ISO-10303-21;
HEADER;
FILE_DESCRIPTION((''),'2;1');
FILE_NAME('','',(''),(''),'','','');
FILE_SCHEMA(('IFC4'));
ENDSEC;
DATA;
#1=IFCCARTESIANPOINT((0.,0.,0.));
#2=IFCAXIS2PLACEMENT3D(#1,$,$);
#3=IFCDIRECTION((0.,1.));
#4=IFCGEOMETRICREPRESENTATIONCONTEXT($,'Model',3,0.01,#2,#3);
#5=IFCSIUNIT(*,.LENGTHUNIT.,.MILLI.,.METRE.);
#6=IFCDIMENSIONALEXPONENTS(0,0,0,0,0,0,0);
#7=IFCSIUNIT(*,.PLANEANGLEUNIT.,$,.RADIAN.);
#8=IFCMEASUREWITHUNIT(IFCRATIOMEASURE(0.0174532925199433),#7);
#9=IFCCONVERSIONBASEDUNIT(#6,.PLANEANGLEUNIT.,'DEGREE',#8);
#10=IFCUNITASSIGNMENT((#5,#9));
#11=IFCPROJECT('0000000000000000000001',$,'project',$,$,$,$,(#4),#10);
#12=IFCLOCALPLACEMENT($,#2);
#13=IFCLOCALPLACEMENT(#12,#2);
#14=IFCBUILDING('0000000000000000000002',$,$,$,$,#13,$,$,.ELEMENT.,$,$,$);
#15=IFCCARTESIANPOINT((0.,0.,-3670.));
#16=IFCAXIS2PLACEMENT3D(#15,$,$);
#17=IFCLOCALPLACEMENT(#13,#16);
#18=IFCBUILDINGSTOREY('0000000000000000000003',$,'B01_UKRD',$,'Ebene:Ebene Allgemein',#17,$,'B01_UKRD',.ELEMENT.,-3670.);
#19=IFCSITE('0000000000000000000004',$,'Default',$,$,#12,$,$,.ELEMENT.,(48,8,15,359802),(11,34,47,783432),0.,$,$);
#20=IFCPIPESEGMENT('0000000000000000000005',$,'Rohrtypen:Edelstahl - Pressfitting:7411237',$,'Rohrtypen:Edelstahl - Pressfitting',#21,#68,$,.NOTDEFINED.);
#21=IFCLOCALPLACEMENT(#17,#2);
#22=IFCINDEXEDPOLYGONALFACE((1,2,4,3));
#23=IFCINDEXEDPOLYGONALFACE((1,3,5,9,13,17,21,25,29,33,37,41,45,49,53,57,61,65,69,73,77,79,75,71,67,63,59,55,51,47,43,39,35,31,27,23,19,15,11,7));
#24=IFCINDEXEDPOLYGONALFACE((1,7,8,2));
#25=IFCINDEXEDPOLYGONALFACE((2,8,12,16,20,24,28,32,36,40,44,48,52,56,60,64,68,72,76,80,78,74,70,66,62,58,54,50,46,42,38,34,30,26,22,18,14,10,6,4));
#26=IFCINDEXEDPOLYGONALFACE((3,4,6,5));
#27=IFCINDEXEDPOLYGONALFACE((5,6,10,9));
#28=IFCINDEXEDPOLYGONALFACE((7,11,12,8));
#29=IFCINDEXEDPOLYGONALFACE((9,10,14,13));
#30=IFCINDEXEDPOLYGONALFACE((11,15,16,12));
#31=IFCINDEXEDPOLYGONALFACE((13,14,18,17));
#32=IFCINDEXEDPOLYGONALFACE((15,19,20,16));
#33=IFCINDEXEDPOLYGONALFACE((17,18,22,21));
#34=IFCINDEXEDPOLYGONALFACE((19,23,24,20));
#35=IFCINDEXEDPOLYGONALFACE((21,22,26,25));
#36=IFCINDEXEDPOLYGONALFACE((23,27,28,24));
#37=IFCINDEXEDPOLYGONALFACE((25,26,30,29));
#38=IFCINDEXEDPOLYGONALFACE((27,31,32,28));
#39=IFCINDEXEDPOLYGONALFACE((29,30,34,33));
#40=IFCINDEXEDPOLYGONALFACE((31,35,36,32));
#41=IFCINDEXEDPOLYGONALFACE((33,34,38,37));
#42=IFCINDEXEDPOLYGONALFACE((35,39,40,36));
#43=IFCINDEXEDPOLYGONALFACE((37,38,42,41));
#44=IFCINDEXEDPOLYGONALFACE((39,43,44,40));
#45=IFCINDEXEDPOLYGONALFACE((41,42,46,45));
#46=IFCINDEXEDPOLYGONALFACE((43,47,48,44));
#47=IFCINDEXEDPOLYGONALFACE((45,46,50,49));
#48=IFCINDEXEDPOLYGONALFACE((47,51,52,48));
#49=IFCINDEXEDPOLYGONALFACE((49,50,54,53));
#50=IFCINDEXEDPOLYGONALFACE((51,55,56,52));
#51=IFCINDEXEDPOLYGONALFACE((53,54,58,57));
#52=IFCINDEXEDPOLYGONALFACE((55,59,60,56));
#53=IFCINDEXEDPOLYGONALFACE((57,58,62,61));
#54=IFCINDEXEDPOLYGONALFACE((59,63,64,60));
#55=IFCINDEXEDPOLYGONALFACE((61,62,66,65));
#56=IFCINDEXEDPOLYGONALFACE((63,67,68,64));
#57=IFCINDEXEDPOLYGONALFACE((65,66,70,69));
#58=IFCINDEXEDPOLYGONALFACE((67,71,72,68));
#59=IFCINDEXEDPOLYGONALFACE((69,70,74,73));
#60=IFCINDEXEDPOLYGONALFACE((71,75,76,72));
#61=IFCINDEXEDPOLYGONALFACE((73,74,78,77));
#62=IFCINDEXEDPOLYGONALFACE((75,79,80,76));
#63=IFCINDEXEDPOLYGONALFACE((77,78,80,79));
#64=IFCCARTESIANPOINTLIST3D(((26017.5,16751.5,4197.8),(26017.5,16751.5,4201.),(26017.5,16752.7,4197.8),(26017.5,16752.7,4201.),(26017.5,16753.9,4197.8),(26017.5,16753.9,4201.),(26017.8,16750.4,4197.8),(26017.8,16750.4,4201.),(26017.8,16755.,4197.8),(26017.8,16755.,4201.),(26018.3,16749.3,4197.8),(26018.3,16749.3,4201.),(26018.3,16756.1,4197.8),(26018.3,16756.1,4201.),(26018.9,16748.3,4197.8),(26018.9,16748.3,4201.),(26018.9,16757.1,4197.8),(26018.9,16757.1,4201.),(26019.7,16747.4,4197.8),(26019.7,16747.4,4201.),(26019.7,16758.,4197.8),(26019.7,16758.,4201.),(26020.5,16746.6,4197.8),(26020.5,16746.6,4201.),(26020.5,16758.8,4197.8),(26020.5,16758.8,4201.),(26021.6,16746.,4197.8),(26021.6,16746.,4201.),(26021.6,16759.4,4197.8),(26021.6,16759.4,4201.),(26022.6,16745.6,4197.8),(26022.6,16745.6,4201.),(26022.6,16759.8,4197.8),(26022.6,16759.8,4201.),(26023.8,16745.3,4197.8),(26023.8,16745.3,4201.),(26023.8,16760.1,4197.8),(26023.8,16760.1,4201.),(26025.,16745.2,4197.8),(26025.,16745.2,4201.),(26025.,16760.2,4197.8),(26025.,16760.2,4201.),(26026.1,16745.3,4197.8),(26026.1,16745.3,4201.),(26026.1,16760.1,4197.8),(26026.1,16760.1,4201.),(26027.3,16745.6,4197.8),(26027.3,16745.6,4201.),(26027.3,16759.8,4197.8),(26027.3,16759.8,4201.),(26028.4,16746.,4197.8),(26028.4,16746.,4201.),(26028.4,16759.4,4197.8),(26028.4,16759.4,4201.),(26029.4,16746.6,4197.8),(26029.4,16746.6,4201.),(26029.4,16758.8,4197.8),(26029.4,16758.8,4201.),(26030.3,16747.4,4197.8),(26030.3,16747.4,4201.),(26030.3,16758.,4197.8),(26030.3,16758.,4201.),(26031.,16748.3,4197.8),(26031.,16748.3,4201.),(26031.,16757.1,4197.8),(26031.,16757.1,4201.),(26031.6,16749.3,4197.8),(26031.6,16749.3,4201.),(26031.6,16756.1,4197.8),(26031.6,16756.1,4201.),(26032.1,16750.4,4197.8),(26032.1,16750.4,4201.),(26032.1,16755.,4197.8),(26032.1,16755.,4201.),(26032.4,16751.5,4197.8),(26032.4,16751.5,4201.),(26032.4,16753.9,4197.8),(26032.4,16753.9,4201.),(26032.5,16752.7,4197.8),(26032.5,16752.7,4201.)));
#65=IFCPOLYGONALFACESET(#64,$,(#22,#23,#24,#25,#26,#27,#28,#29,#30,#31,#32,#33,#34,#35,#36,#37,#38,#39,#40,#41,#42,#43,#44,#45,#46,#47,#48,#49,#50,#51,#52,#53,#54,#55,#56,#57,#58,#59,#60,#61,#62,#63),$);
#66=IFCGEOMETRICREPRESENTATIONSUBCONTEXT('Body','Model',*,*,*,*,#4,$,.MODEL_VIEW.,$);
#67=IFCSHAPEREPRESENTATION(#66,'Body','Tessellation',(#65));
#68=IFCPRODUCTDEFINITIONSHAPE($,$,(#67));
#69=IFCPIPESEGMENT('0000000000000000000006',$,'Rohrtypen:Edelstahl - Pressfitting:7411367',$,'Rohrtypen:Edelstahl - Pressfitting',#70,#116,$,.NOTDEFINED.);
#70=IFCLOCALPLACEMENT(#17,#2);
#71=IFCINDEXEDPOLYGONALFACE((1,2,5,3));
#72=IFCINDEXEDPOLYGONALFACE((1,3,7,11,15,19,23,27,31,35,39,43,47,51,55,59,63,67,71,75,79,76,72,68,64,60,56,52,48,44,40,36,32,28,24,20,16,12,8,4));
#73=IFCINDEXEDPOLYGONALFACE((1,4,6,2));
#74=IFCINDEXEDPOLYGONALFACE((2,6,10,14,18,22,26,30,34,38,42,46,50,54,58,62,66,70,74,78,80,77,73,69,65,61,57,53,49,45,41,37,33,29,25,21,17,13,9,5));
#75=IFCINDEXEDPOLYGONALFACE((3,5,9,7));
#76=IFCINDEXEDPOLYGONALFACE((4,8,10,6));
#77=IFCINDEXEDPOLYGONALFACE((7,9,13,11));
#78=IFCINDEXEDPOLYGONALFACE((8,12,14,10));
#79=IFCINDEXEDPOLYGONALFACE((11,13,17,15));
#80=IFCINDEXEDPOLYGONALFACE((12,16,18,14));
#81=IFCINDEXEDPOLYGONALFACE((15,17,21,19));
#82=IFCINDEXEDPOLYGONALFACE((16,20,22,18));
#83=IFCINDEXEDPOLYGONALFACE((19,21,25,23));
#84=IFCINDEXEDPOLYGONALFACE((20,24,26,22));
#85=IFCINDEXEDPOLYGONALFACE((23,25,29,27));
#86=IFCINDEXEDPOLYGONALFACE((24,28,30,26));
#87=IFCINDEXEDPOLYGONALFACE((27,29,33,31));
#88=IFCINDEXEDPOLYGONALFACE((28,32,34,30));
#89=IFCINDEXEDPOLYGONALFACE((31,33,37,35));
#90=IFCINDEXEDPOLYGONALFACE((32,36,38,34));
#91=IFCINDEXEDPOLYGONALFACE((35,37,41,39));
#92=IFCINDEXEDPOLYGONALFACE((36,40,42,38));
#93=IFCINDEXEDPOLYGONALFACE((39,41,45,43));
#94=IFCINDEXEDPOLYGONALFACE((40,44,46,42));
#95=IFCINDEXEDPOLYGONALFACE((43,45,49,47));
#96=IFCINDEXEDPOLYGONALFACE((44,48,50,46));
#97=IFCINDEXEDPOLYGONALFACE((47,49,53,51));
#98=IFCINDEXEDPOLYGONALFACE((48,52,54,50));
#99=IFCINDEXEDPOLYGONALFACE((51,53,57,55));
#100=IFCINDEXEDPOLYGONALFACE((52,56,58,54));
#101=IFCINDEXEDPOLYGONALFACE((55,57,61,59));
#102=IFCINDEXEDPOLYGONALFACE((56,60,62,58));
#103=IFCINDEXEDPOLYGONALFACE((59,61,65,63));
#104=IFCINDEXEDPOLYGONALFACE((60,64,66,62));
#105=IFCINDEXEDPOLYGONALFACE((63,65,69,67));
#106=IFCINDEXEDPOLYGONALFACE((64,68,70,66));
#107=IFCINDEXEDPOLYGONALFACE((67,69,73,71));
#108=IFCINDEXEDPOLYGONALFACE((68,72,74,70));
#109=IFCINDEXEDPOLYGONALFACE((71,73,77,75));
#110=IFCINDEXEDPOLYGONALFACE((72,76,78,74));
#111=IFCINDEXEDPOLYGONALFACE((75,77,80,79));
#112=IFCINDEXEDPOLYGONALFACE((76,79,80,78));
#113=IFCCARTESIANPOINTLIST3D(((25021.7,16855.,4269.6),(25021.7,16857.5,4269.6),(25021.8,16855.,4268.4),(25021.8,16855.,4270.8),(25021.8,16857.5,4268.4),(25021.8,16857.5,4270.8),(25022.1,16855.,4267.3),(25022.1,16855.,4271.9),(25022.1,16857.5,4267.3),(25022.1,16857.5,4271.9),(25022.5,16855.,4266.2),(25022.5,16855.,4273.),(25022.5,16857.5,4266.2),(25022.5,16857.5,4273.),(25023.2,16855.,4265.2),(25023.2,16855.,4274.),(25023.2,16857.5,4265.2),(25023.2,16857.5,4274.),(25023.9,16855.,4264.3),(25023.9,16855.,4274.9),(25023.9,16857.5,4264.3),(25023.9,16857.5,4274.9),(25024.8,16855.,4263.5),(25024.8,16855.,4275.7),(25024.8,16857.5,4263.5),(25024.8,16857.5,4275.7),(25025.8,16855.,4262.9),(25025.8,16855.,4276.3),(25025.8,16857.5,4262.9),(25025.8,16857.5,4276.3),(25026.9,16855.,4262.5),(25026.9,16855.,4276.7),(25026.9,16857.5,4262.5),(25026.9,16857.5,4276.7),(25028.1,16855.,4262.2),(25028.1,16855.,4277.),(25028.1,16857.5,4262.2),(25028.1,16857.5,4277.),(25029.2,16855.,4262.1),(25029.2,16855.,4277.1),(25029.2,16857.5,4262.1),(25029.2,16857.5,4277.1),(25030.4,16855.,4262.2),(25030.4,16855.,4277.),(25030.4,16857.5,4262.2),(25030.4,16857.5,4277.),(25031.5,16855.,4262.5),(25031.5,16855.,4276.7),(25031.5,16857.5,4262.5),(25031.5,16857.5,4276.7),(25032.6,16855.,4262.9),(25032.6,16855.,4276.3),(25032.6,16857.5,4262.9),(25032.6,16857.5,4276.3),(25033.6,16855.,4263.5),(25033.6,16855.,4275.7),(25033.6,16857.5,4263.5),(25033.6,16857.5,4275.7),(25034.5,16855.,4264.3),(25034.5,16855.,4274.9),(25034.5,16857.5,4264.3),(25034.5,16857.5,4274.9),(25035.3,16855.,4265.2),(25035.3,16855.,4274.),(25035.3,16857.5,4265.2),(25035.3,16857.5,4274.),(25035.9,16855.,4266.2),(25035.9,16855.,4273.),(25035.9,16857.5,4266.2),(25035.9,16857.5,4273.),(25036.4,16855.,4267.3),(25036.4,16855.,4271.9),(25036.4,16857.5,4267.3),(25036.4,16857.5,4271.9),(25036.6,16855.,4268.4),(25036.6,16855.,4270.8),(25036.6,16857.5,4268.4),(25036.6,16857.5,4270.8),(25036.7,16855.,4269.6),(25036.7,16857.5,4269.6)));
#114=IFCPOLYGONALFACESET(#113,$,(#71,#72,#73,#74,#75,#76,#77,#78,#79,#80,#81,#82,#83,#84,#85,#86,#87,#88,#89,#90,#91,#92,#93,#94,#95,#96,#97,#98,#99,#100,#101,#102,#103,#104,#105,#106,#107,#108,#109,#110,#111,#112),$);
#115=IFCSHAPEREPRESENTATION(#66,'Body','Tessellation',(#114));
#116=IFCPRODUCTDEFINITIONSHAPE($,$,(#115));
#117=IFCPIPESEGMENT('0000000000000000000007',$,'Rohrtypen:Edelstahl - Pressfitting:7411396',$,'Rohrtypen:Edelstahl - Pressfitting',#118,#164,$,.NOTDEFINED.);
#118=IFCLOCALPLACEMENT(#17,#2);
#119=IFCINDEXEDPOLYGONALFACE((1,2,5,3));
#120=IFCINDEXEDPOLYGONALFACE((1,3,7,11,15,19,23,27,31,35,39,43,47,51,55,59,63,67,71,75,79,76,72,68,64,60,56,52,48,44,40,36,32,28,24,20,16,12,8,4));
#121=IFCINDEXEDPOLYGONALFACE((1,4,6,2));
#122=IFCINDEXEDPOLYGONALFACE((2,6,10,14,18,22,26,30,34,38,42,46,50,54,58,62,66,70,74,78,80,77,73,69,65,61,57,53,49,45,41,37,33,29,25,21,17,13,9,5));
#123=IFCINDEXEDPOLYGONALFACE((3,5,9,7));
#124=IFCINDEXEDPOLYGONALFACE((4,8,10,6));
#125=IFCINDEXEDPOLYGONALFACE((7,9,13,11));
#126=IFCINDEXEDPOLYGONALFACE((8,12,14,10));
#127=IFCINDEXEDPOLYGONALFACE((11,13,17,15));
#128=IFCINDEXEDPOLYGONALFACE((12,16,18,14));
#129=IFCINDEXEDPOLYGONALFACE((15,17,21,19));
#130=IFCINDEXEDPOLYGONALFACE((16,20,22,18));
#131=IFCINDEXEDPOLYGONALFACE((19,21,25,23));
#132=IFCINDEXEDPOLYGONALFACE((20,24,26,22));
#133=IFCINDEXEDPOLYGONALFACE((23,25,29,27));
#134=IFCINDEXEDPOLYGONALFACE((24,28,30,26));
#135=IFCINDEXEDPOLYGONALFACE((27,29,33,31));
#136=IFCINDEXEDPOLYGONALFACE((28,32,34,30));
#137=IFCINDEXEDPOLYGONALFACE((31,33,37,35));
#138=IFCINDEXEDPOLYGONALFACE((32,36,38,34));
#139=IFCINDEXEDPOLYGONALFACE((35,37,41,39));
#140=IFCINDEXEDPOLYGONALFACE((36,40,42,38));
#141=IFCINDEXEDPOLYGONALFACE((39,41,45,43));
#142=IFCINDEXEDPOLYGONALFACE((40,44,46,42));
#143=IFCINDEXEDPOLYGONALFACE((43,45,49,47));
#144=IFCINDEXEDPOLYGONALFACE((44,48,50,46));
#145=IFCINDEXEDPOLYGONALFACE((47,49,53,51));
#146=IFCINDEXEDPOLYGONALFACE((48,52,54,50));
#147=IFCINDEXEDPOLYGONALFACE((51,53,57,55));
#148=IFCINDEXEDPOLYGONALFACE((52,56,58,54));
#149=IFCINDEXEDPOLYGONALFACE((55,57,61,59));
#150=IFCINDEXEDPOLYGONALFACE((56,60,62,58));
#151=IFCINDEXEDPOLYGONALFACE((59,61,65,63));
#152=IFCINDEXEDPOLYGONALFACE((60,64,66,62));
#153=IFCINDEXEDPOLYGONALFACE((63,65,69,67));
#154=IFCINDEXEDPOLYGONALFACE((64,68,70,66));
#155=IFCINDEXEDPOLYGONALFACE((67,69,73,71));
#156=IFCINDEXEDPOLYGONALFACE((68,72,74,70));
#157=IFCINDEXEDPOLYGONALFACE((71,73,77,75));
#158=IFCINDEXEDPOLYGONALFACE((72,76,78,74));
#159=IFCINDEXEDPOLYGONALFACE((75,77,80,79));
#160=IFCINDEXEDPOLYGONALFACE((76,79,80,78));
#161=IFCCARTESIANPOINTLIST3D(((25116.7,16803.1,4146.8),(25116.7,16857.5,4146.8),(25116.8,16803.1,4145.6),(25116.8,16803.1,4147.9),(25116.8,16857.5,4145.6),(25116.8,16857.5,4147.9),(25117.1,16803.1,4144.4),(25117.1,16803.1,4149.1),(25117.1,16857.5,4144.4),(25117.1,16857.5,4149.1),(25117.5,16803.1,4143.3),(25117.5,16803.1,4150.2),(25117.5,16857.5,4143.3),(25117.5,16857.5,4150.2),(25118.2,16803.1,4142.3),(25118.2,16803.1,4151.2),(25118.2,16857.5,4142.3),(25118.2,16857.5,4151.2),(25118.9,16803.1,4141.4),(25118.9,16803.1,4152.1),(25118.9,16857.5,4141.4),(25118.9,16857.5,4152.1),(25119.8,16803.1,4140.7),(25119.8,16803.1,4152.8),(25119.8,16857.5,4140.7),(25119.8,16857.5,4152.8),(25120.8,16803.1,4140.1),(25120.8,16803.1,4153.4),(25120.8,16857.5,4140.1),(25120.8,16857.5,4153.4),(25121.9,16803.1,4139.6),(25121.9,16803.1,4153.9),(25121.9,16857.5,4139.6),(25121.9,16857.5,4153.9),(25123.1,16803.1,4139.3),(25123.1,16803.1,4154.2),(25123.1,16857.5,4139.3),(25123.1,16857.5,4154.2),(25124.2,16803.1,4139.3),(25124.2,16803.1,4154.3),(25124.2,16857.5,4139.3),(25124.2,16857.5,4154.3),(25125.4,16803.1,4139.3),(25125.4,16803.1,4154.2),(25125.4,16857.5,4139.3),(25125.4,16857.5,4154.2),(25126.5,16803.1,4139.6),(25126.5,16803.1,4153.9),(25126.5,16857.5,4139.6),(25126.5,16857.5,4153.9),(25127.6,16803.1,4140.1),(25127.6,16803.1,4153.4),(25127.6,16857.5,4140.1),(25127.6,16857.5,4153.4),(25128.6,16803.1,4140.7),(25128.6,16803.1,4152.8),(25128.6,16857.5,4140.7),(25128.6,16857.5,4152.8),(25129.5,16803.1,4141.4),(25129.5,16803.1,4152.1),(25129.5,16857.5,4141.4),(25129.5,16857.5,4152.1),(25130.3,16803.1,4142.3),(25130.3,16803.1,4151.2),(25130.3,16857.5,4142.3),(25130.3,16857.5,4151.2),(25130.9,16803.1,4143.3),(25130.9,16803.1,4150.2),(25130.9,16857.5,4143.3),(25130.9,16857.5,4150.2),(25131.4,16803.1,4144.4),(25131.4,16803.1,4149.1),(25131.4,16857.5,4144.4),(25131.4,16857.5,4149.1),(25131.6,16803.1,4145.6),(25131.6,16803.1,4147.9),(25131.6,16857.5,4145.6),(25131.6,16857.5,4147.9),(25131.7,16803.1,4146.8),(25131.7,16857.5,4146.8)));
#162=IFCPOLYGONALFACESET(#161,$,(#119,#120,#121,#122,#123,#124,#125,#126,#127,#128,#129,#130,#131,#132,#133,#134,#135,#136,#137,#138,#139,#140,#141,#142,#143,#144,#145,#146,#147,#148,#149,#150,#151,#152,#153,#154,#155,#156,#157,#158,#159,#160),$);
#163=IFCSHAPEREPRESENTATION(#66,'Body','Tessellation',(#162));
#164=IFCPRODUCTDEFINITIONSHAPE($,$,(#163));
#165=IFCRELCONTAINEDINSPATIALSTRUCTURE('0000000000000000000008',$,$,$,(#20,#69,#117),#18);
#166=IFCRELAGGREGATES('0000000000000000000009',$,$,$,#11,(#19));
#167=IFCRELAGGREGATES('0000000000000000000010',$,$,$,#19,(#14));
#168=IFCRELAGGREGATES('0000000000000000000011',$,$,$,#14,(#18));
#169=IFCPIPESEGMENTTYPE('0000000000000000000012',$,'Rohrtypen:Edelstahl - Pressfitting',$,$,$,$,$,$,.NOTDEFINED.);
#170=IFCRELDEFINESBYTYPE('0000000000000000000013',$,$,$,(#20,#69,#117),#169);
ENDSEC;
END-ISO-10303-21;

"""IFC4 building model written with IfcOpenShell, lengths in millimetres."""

from ifc_helpers import new_model, entity, si_unit, converted_unit, direction, frame, origin, place, context, subcontext, project, spatial, indexed_curve, outline, extrude, type_object, element, save


model = new_model("IFC4")

# Units and contexts
model_context = context("Model", 3, precision=0.01, world=origin(), true_north=direction((0.0, 1.0)))
body_context = subcontext(model_context, "Body", "Model", "MODEL_VIEW")
ifc_project = project(units=[si_unit("LENGTHUNIT", "METRE", prefix="MILLI"), converted_unit("PLANEANGLEUNIT", "DEGREE", entity("IfcRatioMeasure", 0.0174532925199433), si_unit("PLANEANGLEUNIT", "RADIAN"), dimensions=[0, 0, 0, 0, 0, 0, 0])], contexts=[model_context])

# Site, building, storey
site_placement = place(None, origin())
site = spatial("IfcSite", under=ifc_project, at=site_placement, Name="Default", CompositionType="ELEMENT", RefLatitude=(48, 8, 15, 359802), RefLongitude=(11, 34, 47, 783432), RefElevation=0.0)
building_placement = place(site_placement, origin())
building = spatial("IfcBuilding", under=site, at=building_placement, CompositionType="ELEMENT")
storey_placement = place(building_placement, frame((0.0, 0.0, -3670.0)))
storey = spatial("IfcBuildingStorey", under=building, at=storey_placement, Name="B01_UKRD", ObjectType="Ebene:Ebene Allgemein", LongName="B01_UKRD", CompositionType="ELEMENT", Elevation=-3670.0)

# Pipe segments
pipe_segment_type = type_object("IfcPipeSegmentType", Name="Rohrtypen:Edelstahl - Pressfitting", PredefinedType="NOTDEFINED")
pipe_segment_1_placement = place(storey_placement, origin())
element("IfcPipeSegment", 1, at=pipe_segment_1_placement, inside=storey, type_object=pipe_segment_type, Name="Rohrtypen:Edelstahl - Pressfitting:7411237", ObjectType="Rohrtypen:Edelstahl - Pressfitting", PredefinedType="NOTDEFINED", context=body_context, shape_type="SweptSolid", body=[
    extrude(outline(indexed_curve([(7.5, 0.0), (7.4, 1.2), (7.1, 2.3), (6.7, 3.4), (6.1, 4.4), (5.3, 5.3), (4.4, 6.1), (3.4, 6.7), (2.3, 7.1), (1.2, 7.4), (0.0, 7.5), (-1.2, 7.4), (-2.3, 7.1), (-3.4, 6.7), (-4.4, 6.1), (-5.3, 5.3), (-6.1, 4.4), (-6.7, 3.4), (-7.1, 2.3), (-7.4, 1.2), (-7.5, 0.0), (-7.4, -1.2), (-7.1, -2.3), (-6.7, -3.4), (-6.1, -4.4), (-5.3, -5.3), (-4.4, -6.1), (-3.4, -6.7), (-2.3, -7.1), (-1.2, -7.4), (0.0, -7.5), (1.2, -7.4), (2.3, -7.1), (3.4, -6.7), (4.4, -6.1), (5.3, -5.3), (6.1, -4.4), (6.7, -3.4), (7.1, -2.3), (7.4, -1.2), (7.5, 0.0)], self_intersect=False)), frame((26025.0, 16752.7, 4197.8), z_axis=(0.0, 0.0, 1.0), x_axis=(-1.0, 0.0, 0.0)), (0.0, 0.0, 1.0), 3.2),
])
pipe_segment_2_placement = place(storey_placement, origin())
element("IfcPipeSegment", 2, at=pipe_segment_2_placement, inside=storey, type_object=pipe_segment_type, Name="Rohrtypen:Edelstahl - Pressfitting:7411367", ObjectType="Rohrtypen:Edelstahl - Pressfitting", PredefinedType="NOTDEFINED", context=body_context, shape_type="SweptSolid", body=[
    extrude(outline(indexed_curve([(7.5, 0.0), (7.4, 1.2), (7.1, 2.3), (6.7, 3.4), (6.1, 4.4), (5.3, 5.3), (4.4, 6.1), (3.4, 6.7), (2.3, 7.1), (1.2, 7.4), (0.0, 7.5), (-1.2, 7.4), (-2.3, 7.1), (-3.4, 6.7), (-4.4, 6.1), (-5.3, 5.3), (-6.1, 4.4), (-6.7, 3.4), (-7.1, 2.3), (-7.4, 1.2), (-7.5, 0.0), (-7.4, -1.2), (-7.1, -2.3), (-6.7, -3.4), (-6.1, -4.4), (-5.3, -5.3), (-4.4, -6.1), (-3.4, -6.7), (-2.3, -7.1), (-1.2, -7.4), (0.0, -7.5), (1.2, -7.4), (2.3, -7.1), (3.4, -6.7), (4.4, -6.1), (5.3, -5.3), (6.1, -4.4), (6.7, -3.4), (7.1, -2.3), (7.4, -1.2), (7.5, 0.0)], self_intersect=False)), frame((25029.2, 16855.0, 4269.6), z_axis=(0.0, 1.0, 0.0), x_axis=(-1.0, 0.0, 0.0)), (0.0, 0.0, 1.0), 2.6),
])
pipe_segment_3_placement = place(storey_placement, origin())
element("IfcPipeSegment", 3, at=pipe_segment_3_placement, inside=storey, type_object=pipe_segment_type, Name="Rohrtypen:Edelstahl - Pressfitting:7411396", ObjectType="Rohrtypen:Edelstahl - Pressfitting", PredefinedType="NOTDEFINED", context=body_context, shape_type="SweptSolid", body=[
    extrude(outline(indexed_curve([(7.5, 0.0), (7.4, 1.2), (7.1, 2.3), (6.7, 3.4), (6.1, 4.4), (5.3, 5.3), (4.4, 6.1), (3.4, 6.7), (2.3, 7.1), (1.2, 7.4), (0.0, 7.5), (-1.2, 7.4), (-2.3, 7.1), (-3.4, 6.7), (-4.4, 6.1), (-5.3, 5.3), (-6.1, 4.4), (-6.7, 3.4), (-7.1, 2.3), (-7.4, 1.2), (-7.5, 0.0), (-7.4, -1.2), (-7.1, -2.3), (-6.7, -3.4), (-6.1, -4.4), (-5.3, -5.3), (-4.4, -6.1), (-3.4, -6.7), (-2.3, -7.1), (-1.2, -7.4), (0.0, -7.5), (1.2, -7.4), (2.3, -7.1), (3.4, -6.7), (4.4, -6.1), (5.3, -5.3), (6.1, -4.4), (6.7, -3.4), (7.1, -2.3), (7.4, -1.2), (7.5, 0.0)], self_intersect=False)), frame((25124.2, 16803.1, 4146.8), z_axis=(0.0, 1.0, 0.0), x_axis=(-1.0, 0.0, 0.0)), (0.0, 0.0, 1.0), 54.4),
])

save(model, "model.ifc")
